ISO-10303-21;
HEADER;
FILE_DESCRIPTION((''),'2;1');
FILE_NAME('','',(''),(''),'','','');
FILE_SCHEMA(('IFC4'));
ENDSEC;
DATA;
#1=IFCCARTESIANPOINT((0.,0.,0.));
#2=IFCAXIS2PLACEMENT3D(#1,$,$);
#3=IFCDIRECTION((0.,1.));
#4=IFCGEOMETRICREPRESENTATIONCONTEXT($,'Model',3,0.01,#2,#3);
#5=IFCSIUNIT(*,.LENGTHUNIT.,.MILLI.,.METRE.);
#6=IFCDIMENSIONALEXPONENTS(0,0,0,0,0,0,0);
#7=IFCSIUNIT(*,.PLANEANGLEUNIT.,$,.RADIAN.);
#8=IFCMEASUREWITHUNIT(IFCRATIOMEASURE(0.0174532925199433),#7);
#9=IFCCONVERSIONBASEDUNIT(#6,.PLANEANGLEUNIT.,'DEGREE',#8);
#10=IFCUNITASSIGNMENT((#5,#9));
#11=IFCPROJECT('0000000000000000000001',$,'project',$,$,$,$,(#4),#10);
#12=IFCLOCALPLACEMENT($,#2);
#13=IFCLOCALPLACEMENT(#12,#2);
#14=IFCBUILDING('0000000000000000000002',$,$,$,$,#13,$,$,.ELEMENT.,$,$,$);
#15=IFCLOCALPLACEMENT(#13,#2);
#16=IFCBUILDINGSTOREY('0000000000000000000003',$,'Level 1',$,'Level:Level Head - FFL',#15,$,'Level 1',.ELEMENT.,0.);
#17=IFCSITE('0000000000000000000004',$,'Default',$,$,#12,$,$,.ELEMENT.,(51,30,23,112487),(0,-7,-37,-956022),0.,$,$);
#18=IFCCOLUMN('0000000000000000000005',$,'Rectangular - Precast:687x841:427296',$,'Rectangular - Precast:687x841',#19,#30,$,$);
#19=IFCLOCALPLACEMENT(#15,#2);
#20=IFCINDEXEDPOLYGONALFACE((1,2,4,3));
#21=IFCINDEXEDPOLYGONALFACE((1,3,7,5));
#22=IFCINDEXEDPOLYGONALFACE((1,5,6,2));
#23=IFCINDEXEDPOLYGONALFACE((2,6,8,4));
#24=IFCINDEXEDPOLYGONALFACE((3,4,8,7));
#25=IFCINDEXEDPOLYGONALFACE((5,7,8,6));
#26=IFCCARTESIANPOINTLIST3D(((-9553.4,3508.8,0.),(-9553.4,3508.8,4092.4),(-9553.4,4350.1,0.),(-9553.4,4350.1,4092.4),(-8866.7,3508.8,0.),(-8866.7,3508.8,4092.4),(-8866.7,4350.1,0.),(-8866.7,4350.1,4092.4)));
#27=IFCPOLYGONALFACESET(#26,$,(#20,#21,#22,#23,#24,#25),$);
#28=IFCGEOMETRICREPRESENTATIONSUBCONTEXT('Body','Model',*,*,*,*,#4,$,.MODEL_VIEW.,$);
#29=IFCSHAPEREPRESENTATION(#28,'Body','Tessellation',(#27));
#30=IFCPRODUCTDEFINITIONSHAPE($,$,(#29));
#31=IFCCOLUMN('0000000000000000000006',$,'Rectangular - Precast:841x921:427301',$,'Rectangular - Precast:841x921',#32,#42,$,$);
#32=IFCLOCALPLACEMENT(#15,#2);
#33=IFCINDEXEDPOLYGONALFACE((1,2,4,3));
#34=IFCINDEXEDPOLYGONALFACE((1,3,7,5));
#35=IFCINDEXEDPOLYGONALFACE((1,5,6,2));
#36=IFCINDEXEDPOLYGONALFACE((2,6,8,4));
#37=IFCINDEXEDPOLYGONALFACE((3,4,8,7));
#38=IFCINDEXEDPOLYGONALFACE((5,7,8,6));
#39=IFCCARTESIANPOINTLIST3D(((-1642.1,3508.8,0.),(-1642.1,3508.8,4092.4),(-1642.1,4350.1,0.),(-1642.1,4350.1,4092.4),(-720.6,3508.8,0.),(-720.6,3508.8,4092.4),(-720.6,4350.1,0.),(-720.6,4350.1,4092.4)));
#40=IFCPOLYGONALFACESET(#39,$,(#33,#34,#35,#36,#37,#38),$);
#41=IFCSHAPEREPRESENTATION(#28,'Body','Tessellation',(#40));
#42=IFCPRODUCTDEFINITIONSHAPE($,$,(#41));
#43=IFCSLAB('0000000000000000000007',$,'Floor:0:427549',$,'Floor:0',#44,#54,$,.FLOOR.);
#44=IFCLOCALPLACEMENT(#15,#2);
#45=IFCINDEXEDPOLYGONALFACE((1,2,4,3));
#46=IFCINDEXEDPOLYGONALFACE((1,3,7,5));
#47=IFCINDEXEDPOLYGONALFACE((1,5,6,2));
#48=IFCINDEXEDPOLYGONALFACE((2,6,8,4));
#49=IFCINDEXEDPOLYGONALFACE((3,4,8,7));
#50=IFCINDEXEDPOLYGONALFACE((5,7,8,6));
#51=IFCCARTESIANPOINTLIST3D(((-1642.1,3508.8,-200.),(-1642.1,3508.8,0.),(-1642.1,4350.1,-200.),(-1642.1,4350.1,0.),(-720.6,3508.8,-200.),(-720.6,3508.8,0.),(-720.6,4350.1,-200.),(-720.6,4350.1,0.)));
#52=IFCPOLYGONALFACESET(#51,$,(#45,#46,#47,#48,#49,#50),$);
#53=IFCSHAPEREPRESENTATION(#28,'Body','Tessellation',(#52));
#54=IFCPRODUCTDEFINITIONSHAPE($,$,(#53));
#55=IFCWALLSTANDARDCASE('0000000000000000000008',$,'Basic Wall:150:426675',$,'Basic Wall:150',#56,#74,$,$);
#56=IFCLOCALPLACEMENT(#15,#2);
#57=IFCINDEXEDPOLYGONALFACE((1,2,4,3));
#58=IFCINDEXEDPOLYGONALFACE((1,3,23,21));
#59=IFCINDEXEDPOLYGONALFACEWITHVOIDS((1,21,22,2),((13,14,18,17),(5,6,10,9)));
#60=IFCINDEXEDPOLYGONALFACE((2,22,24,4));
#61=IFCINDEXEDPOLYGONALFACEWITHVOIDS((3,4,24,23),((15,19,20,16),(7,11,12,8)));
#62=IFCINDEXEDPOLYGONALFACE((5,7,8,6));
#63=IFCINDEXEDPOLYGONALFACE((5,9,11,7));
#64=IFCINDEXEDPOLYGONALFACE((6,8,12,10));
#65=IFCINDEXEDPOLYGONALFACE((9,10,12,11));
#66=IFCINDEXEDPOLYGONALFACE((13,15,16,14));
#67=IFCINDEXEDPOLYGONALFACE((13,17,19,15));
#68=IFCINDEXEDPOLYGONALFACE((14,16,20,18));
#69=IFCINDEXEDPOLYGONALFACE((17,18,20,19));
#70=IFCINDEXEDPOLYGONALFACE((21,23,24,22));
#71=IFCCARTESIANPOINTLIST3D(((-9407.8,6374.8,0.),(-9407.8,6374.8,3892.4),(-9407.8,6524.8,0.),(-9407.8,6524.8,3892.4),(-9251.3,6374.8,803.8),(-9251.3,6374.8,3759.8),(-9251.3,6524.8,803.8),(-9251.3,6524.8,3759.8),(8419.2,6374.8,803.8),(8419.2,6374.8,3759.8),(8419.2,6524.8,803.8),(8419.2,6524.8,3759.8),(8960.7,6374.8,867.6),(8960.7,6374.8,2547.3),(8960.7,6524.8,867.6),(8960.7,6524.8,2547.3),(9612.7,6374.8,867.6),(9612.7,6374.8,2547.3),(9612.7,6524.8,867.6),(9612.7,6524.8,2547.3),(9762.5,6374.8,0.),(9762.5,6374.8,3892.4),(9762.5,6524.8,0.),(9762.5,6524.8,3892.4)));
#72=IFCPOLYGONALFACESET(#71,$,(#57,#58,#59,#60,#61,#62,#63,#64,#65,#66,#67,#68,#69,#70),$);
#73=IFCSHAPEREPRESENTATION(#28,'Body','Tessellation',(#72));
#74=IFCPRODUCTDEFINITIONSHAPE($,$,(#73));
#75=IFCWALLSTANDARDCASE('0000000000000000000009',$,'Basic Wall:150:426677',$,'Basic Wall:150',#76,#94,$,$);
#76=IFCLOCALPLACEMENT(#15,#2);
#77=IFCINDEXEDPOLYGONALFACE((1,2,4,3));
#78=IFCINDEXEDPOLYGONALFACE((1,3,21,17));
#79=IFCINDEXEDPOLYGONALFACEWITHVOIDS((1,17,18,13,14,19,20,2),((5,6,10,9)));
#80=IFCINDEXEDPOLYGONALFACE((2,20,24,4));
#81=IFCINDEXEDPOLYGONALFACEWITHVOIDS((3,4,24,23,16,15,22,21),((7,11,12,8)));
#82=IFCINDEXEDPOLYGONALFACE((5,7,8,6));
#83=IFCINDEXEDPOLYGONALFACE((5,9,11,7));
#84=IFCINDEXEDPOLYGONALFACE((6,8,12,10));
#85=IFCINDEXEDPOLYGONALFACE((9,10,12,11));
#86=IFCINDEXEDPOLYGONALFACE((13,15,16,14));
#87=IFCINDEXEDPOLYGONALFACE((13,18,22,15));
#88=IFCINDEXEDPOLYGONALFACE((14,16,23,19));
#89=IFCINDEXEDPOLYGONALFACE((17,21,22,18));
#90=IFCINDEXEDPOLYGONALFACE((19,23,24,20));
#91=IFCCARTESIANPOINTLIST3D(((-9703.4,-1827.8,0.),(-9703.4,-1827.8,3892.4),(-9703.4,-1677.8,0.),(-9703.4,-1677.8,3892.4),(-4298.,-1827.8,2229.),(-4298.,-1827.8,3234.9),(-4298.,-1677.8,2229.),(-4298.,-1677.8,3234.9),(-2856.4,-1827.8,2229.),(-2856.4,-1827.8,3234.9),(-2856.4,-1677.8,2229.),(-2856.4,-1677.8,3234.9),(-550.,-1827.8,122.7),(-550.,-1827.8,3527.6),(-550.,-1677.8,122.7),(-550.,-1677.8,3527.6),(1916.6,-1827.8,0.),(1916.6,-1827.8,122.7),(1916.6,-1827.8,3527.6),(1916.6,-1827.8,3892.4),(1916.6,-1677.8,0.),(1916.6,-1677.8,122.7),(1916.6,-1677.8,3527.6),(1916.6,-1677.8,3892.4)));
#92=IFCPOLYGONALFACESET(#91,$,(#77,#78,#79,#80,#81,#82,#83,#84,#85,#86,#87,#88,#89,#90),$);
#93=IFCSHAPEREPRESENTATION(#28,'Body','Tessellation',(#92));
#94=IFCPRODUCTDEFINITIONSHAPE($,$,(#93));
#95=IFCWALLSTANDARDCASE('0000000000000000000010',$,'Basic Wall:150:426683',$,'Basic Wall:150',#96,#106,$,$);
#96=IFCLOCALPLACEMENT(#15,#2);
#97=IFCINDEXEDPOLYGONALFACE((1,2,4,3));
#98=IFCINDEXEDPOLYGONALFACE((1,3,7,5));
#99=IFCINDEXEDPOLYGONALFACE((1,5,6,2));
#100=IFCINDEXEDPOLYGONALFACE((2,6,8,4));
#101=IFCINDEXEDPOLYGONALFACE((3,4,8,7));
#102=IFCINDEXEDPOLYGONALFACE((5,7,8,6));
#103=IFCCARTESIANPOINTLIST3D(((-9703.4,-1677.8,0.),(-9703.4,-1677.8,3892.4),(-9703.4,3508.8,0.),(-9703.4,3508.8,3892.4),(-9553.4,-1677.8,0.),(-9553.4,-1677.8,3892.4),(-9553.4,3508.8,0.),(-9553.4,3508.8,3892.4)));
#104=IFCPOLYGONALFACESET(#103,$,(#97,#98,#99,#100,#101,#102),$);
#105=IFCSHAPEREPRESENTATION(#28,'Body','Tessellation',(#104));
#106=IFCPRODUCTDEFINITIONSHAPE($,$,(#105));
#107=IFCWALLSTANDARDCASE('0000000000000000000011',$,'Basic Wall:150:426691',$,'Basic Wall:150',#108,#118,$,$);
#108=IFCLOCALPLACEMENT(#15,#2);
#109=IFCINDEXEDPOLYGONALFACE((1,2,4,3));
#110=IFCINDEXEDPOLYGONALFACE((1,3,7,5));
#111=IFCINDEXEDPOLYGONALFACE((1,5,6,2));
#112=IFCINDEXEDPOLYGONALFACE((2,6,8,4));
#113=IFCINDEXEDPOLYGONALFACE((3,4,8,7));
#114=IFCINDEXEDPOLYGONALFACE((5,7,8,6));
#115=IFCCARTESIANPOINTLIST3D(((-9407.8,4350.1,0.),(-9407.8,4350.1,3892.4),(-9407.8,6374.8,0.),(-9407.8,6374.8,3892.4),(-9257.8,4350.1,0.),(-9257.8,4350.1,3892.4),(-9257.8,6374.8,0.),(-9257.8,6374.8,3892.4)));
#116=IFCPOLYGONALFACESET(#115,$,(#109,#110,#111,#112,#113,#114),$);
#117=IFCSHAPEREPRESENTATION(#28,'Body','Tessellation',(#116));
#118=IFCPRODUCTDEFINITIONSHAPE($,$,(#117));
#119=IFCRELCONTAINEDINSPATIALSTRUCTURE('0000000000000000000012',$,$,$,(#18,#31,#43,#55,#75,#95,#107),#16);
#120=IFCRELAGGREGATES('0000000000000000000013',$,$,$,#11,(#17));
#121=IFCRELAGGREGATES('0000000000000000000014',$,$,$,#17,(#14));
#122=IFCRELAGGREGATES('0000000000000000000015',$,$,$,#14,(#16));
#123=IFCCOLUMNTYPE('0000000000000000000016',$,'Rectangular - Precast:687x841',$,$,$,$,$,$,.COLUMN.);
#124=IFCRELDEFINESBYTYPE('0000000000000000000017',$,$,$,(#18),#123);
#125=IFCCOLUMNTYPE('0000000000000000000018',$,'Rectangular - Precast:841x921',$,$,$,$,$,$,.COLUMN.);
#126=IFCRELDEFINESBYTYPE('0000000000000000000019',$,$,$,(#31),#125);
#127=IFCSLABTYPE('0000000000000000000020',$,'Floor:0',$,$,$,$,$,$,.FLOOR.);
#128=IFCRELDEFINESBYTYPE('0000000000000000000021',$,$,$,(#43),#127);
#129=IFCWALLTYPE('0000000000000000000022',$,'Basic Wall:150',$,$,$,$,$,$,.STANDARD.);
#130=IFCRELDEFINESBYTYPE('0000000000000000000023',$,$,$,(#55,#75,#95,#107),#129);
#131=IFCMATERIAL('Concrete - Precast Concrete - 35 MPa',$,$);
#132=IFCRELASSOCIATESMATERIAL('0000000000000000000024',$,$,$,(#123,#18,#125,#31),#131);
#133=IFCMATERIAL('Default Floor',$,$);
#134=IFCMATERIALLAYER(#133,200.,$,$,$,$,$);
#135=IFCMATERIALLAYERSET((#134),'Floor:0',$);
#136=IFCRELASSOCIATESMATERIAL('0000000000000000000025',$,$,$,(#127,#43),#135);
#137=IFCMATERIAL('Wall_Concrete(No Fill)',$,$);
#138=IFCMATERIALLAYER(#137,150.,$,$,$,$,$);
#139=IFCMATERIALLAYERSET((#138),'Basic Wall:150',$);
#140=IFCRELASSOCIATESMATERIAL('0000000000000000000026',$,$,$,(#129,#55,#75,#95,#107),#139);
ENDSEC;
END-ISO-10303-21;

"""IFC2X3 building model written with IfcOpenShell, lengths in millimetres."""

from ifc_helpers import new_model, entity, si_unit, converted_unit, direction, frame, frame_2d, origin, origin_2d_with_axis, place, context, subcontext, project, spatial, rectangle, extrude, source, transform, mapped, material, layer, layer_set, layer_usage, type_object, type_shapes, element, save


model = new_model("IFC2X3")

# Units and contexts
model_context = context("Model", 3, precision=0.01, world=origin(), true_north=direction((0.0, 1.0)))
body_context = subcontext(model_context, "Body", "Model", "MODEL_VIEW")
ifc_project = project(units=[si_unit("LENGTHUNIT", "METRE", prefix="MILLI"), converted_unit("PLANEANGLEUNIT", "DEGREE", entity("IfcRatioMeasure", 0.0174532925199433), si_unit("PLANEANGLEUNIT", "RADIAN"), dimensions=[0, 0, 0, 0, 0, 0, 0])], contexts=[model_context])

# Site, building, storey
site_placement = place(None, origin())
site = spatial("IfcSite", under=ifc_project, at=site_placement, Name="Default", CompositionType="ELEMENT", RefLatitude=(51, 30, 23, 112487), RefLongitude=(0, -7, -37, -956022), RefElevation=0.0)
building_placement = place(site_placement, origin())
building = spatial("IfcBuilding", under=site, at=building_placement, CompositionType="ELEMENT")
storey_placement = place(building_placement, origin())
storey = spatial("IfcBuildingStorey", under=building, at=storey_placement, Name="Level 1", ObjectType="Level:Level Head - FFL", LongName="Level 1", CompositionType="ELEMENT", Elevation=0.0)

# Columns
ifc_material_1 = material(Name="Concrete - Precast Concrete - 35 MPa")
column_type_1 = type_object("IfcColumnType", Name="Rectangular - Precast:687x841", PredefinedType="COLUMN", material=ifc_material_1)
shared_shape_1 = source(origin(), body_context, "Body", "SweptSolid", [
    extrude(rectangle(XDim=841.3, YDim=686.7, at=frame_2d((0.0, 0.0), x_axis=(1.0, 0.0))), frame((0.0, 0.0, 0.0), z_axis=(0.0, 0.0, 1.0), x_axis=(0.0, -1.0, 0.0)), (0.0, 0.0, 1.0), 4092.4),
])
type_shapes(column_type_1, [shared_shape_1])
column_1_placement = place(storey_placement, frame((-9210.0, 3929.4, 0.0)))
element("IfcColumn", 1, at=column_1_placement, inside=storey, type_object=column_type_1, material=ifc_material_1, Name="Rectangular - Precast:687x841:427296", ObjectType="Rectangular - Precast:687x841", context=body_context, shape_type="MappedRepresentation", body=[
    mapped(shared_shape_1, transform((0.0, 0.0, 0.0), scale=1.0)),
])
column_type_2 = type_object("IfcColumnType", Name="Rectangular - Precast:841x921", PredefinedType="COLUMN", material=ifc_material_1)
shared_shape_2 = source(origin(), body_context, "Body", "SweptSolid", [
    extrude(rectangle(XDim=921.5, YDim=841.3, at=frame_2d((0.0, 0.0), x_axis=(1.0, 0.0))), frame((0.0, 0.0, 0.0), z_axis=(0.0, 0.0, 1.0), x_axis=(0.0, -1.0, 0.0)), (0.0, 0.0, 1.0), 4092.4),
])
type_shapes(column_type_2, [shared_shape_2])
column_2_placement = place(storey_placement, frame((-1181.4, 3929.4, 0.0), z_axis=(0.0, 0.0, 1.0), x_axis=(-0.000004, 1.0, 0.0)))
element("IfcColumn", 2, at=column_2_placement, inside=storey, type_object=column_type_2, material=ifc_material_1, Name="Rectangular - Precast:841x921:427301", ObjectType="Rectangular - Precast:841x921", context=body_context, shape_type="MappedRepresentation", body=[
    mapped(shared_shape_2, transform((0.0, 0.0, 0.0), scale=1.0)),
])

# Slab
ifc_material_2 = material(Name="Default Floor")
ifc_layer_1 = layer(ifc_material_2, 200.0)
ifc_layer_set_1 = layer_set([ifc_layer_1], Name="Floor:0")
ifc_layer_usage_1 = layer_usage(ifc_layer_set_1, "AXIS3", "POSITIVE", 0.0)
slab_type_1 = type_object("IfcSlabType", Name="Floor:0", PredefinedType="FLOOR", material=ifc_layer_set_1)
slab_1_placement = place(storey_placement, origin())
element("IfcSlab", 3, at=slab_1_placement, inside=storey, type_object=slab_type_1, material=ifc_layer_usage_1, Name="Floor:0:427549", ObjectType="Floor:0", PredefinedType="FLOOR", context=body_context, shape_type="SweptSolid", body=[
    extrude(rectangle(XDim=841.3, YDim=921.5, at=frame_2d((0.0, 0.0), x_axis=(1.0, 0.0))), frame((-1181.4, 3929.4, 0.0), z_axis=(0.0, 0.0, -1.0), x_axis=(0.0, 1.0, 0.0)), (0.0, 0.0, 1.0), 200.0),
])

# Walls, openings
ifc_material_3 = material(Name="Wall_Concrete(No Fill)")
ifc_layer_2 = layer(ifc_material_3, 150.0)
ifc_layer_set_2 = layer_set([ifc_layer_2], Name="Basic Wall:150")
ifc_layer_usage_2 = layer_usage(ifc_layer_set_2, "AXIS2", "NEGATIVE", 75.0)
wall_type = type_object("IfcWallType", Name="Basic Wall:150", PredefinedType="STANDARD", material=ifc_layer_set_2)
wall_1_placement = place(storey_placement, frame((-9407.8, 6449.8, 0.0)))
wall_1 = element("IfcWallStandardCase", 4, at=wall_1_placement, inside=storey, type_object=wall_type, material=ifc_layer_usage_2, Name="Basic Wall:150:426675", ObjectType="Basic Wall:150", context=body_context, shape_type="SweptSolid", body=[
    extrude(rectangle(XDim=19170.3, YDim=150.0, at=frame_2d((9585.1, 0.0), x_axis=(-1.0, 0.0))), origin(), (0.0, 0.0, 1.0), 3892.4),
])
opening_1_placement = place(wall_1_placement, origin())
element("IfcOpeningElement", 5, at=opening_1_placement, cuts=wall_1, ObjectType="Opening", context=body_context, shape_type="SweptSolid", body=[
    extrude(rectangle(XDim=2956.0, YDim=17670.5, at=frame_2d((0.0, 0.0), x_axis=(1.0, 0.0))), frame((8991.8, -75.0, 2281.8), z_axis=(0.0, 1.0, 0.0), x_axis=(0.0, 0.0, -1.0)), (0.0, 0.0, 1.0), 150.0),
])
opening_2_placement = place(wall_1_placement, origin())
element("IfcOpeningElement", 6, at=opening_2_placement, cuts=wall_1, ObjectType="Opening", context=body_context, shape_type="SweptSolid", body=[
    extrude(rectangle(XDim=1679.7, YDim=652.1, at=origin_2d_with_axis()), frame((18694.5, -75.0, 1707.5), z_axis=(0.0, 1.0, 0.0), x_axis=(0.0, 0.0, -1.0)), (0.0, 0.0, 1.0), 150.0),
])
ifc_layer_usage_3 = layer_usage(ifc_layer_set_2, "AXIS2", "NEGATIVE", 75.0)
wall_2_placement = place(storey_placement, frame((-9703.4, -1752.8, 0.0)))
wall_2 = element("IfcWallStandardCase", 7, at=wall_2_placement, inside=storey, type_object=wall_type, material=ifc_layer_usage_3, Name="Basic Wall:150:426677", ObjectType="Basic Wall:150", context=body_context, shape_type="SweptSolid", body=[
    extrude(rectangle(XDim=11619.9, YDim=150.0, at=frame_2d((5810.0, 0.0), x_axis=(-1.0, 0.0))), origin(), (0.0, 0.0, 1.0), 3892.4),
])
opening_3_placement = place(wall_2_placement, origin())
element("IfcOpeningElement", 8, at=opening_3_placement, cuts=wall_2, ObjectType="Opening", context=body_context, shape_type="SweptSolid", body=[
    extrude(rectangle(XDim=3404.8, YDim=2466.6, at=origin_2d_with_axis()), frame((10386.7, -75.0, 1825.1), z_axis=(0.0, 1.0, 0.0), x_axis=(0.0, 0.0, -1.0)), (0.0, 0.0, 1.0), 150.0),
])
opening_4_placement = place(wall_2_placement, origin())
element("IfcOpeningElement", 9, at=opening_4_placement, cuts=wall_2, ObjectType="Opening", context=body_context, shape_type="SweptSolid", body=[
    extrude(rectangle(XDim=1005.8, YDim=1441.6, at=frame_2d((0.0, 0.0), x_axis=(1.0, 0.0))), frame((6126.1, -75.0, 2732.0), z_axis=(0.0, 1.0, 0.0), x_axis=(0.0, 0.0, -1.0)), (0.0, 0.0, 1.0), 150.0),
])

# Walls
ifc_layer_usage_4 = layer_usage(ifc_layer_set_2, "AXIS2", "NEGATIVE", 75.0)
wall_3_placement = place(storey_placement, frame((-9628.4, -1677.8, 0.0), z_axis=(0.0, 0.0, 1.0), x_axis=(0.0, 1.0, 0.0)))
element("IfcWallStandardCase", 10, at=wall_3_placement, inside=storey, type_object=wall_type, material=ifc_layer_usage_4, Name="Basic Wall:150:426683", ObjectType="Basic Wall:150", context=body_context, shape_type="SweptSolid", body=[
    extrude(rectangle(XDim=5186.6, YDim=150.0, at=frame_2d((2593.3, 0.0), x_axis=(-1.0, 0.0))), origin(), (0.0, 0.0, 1.0), 3892.4),
])
ifc_layer_usage_5 = layer_usage(ifc_layer_set_2, "AXIS2", "NEGATIVE", 75.0)
wall_4_placement = place(storey_placement, frame((-9332.8, 4350.1, 0.0), z_axis=(0.0, 0.0, 1.0), x_axis=(0.0, 1.0, 0.0)))
element("IfcWallStandardCase", 11, at=wall_4_placement, inside=storey, type_object=wall_type, material=ifc_layer_usage_5, Name="Basic Wall:150:426691", ObjectType="Basic Wall:150", context=body_context, shape_type="SweptSolid", body=[
    extrude(rectangle(XDim=2024.7, YDim=150.0, at=frame_2d((1012.4, 0.0), x_axis=(-1.0, 0.0))), origin(), (0.0, 0.0, 1.0), 3892.4),
])

save(model, "model.ifc")
